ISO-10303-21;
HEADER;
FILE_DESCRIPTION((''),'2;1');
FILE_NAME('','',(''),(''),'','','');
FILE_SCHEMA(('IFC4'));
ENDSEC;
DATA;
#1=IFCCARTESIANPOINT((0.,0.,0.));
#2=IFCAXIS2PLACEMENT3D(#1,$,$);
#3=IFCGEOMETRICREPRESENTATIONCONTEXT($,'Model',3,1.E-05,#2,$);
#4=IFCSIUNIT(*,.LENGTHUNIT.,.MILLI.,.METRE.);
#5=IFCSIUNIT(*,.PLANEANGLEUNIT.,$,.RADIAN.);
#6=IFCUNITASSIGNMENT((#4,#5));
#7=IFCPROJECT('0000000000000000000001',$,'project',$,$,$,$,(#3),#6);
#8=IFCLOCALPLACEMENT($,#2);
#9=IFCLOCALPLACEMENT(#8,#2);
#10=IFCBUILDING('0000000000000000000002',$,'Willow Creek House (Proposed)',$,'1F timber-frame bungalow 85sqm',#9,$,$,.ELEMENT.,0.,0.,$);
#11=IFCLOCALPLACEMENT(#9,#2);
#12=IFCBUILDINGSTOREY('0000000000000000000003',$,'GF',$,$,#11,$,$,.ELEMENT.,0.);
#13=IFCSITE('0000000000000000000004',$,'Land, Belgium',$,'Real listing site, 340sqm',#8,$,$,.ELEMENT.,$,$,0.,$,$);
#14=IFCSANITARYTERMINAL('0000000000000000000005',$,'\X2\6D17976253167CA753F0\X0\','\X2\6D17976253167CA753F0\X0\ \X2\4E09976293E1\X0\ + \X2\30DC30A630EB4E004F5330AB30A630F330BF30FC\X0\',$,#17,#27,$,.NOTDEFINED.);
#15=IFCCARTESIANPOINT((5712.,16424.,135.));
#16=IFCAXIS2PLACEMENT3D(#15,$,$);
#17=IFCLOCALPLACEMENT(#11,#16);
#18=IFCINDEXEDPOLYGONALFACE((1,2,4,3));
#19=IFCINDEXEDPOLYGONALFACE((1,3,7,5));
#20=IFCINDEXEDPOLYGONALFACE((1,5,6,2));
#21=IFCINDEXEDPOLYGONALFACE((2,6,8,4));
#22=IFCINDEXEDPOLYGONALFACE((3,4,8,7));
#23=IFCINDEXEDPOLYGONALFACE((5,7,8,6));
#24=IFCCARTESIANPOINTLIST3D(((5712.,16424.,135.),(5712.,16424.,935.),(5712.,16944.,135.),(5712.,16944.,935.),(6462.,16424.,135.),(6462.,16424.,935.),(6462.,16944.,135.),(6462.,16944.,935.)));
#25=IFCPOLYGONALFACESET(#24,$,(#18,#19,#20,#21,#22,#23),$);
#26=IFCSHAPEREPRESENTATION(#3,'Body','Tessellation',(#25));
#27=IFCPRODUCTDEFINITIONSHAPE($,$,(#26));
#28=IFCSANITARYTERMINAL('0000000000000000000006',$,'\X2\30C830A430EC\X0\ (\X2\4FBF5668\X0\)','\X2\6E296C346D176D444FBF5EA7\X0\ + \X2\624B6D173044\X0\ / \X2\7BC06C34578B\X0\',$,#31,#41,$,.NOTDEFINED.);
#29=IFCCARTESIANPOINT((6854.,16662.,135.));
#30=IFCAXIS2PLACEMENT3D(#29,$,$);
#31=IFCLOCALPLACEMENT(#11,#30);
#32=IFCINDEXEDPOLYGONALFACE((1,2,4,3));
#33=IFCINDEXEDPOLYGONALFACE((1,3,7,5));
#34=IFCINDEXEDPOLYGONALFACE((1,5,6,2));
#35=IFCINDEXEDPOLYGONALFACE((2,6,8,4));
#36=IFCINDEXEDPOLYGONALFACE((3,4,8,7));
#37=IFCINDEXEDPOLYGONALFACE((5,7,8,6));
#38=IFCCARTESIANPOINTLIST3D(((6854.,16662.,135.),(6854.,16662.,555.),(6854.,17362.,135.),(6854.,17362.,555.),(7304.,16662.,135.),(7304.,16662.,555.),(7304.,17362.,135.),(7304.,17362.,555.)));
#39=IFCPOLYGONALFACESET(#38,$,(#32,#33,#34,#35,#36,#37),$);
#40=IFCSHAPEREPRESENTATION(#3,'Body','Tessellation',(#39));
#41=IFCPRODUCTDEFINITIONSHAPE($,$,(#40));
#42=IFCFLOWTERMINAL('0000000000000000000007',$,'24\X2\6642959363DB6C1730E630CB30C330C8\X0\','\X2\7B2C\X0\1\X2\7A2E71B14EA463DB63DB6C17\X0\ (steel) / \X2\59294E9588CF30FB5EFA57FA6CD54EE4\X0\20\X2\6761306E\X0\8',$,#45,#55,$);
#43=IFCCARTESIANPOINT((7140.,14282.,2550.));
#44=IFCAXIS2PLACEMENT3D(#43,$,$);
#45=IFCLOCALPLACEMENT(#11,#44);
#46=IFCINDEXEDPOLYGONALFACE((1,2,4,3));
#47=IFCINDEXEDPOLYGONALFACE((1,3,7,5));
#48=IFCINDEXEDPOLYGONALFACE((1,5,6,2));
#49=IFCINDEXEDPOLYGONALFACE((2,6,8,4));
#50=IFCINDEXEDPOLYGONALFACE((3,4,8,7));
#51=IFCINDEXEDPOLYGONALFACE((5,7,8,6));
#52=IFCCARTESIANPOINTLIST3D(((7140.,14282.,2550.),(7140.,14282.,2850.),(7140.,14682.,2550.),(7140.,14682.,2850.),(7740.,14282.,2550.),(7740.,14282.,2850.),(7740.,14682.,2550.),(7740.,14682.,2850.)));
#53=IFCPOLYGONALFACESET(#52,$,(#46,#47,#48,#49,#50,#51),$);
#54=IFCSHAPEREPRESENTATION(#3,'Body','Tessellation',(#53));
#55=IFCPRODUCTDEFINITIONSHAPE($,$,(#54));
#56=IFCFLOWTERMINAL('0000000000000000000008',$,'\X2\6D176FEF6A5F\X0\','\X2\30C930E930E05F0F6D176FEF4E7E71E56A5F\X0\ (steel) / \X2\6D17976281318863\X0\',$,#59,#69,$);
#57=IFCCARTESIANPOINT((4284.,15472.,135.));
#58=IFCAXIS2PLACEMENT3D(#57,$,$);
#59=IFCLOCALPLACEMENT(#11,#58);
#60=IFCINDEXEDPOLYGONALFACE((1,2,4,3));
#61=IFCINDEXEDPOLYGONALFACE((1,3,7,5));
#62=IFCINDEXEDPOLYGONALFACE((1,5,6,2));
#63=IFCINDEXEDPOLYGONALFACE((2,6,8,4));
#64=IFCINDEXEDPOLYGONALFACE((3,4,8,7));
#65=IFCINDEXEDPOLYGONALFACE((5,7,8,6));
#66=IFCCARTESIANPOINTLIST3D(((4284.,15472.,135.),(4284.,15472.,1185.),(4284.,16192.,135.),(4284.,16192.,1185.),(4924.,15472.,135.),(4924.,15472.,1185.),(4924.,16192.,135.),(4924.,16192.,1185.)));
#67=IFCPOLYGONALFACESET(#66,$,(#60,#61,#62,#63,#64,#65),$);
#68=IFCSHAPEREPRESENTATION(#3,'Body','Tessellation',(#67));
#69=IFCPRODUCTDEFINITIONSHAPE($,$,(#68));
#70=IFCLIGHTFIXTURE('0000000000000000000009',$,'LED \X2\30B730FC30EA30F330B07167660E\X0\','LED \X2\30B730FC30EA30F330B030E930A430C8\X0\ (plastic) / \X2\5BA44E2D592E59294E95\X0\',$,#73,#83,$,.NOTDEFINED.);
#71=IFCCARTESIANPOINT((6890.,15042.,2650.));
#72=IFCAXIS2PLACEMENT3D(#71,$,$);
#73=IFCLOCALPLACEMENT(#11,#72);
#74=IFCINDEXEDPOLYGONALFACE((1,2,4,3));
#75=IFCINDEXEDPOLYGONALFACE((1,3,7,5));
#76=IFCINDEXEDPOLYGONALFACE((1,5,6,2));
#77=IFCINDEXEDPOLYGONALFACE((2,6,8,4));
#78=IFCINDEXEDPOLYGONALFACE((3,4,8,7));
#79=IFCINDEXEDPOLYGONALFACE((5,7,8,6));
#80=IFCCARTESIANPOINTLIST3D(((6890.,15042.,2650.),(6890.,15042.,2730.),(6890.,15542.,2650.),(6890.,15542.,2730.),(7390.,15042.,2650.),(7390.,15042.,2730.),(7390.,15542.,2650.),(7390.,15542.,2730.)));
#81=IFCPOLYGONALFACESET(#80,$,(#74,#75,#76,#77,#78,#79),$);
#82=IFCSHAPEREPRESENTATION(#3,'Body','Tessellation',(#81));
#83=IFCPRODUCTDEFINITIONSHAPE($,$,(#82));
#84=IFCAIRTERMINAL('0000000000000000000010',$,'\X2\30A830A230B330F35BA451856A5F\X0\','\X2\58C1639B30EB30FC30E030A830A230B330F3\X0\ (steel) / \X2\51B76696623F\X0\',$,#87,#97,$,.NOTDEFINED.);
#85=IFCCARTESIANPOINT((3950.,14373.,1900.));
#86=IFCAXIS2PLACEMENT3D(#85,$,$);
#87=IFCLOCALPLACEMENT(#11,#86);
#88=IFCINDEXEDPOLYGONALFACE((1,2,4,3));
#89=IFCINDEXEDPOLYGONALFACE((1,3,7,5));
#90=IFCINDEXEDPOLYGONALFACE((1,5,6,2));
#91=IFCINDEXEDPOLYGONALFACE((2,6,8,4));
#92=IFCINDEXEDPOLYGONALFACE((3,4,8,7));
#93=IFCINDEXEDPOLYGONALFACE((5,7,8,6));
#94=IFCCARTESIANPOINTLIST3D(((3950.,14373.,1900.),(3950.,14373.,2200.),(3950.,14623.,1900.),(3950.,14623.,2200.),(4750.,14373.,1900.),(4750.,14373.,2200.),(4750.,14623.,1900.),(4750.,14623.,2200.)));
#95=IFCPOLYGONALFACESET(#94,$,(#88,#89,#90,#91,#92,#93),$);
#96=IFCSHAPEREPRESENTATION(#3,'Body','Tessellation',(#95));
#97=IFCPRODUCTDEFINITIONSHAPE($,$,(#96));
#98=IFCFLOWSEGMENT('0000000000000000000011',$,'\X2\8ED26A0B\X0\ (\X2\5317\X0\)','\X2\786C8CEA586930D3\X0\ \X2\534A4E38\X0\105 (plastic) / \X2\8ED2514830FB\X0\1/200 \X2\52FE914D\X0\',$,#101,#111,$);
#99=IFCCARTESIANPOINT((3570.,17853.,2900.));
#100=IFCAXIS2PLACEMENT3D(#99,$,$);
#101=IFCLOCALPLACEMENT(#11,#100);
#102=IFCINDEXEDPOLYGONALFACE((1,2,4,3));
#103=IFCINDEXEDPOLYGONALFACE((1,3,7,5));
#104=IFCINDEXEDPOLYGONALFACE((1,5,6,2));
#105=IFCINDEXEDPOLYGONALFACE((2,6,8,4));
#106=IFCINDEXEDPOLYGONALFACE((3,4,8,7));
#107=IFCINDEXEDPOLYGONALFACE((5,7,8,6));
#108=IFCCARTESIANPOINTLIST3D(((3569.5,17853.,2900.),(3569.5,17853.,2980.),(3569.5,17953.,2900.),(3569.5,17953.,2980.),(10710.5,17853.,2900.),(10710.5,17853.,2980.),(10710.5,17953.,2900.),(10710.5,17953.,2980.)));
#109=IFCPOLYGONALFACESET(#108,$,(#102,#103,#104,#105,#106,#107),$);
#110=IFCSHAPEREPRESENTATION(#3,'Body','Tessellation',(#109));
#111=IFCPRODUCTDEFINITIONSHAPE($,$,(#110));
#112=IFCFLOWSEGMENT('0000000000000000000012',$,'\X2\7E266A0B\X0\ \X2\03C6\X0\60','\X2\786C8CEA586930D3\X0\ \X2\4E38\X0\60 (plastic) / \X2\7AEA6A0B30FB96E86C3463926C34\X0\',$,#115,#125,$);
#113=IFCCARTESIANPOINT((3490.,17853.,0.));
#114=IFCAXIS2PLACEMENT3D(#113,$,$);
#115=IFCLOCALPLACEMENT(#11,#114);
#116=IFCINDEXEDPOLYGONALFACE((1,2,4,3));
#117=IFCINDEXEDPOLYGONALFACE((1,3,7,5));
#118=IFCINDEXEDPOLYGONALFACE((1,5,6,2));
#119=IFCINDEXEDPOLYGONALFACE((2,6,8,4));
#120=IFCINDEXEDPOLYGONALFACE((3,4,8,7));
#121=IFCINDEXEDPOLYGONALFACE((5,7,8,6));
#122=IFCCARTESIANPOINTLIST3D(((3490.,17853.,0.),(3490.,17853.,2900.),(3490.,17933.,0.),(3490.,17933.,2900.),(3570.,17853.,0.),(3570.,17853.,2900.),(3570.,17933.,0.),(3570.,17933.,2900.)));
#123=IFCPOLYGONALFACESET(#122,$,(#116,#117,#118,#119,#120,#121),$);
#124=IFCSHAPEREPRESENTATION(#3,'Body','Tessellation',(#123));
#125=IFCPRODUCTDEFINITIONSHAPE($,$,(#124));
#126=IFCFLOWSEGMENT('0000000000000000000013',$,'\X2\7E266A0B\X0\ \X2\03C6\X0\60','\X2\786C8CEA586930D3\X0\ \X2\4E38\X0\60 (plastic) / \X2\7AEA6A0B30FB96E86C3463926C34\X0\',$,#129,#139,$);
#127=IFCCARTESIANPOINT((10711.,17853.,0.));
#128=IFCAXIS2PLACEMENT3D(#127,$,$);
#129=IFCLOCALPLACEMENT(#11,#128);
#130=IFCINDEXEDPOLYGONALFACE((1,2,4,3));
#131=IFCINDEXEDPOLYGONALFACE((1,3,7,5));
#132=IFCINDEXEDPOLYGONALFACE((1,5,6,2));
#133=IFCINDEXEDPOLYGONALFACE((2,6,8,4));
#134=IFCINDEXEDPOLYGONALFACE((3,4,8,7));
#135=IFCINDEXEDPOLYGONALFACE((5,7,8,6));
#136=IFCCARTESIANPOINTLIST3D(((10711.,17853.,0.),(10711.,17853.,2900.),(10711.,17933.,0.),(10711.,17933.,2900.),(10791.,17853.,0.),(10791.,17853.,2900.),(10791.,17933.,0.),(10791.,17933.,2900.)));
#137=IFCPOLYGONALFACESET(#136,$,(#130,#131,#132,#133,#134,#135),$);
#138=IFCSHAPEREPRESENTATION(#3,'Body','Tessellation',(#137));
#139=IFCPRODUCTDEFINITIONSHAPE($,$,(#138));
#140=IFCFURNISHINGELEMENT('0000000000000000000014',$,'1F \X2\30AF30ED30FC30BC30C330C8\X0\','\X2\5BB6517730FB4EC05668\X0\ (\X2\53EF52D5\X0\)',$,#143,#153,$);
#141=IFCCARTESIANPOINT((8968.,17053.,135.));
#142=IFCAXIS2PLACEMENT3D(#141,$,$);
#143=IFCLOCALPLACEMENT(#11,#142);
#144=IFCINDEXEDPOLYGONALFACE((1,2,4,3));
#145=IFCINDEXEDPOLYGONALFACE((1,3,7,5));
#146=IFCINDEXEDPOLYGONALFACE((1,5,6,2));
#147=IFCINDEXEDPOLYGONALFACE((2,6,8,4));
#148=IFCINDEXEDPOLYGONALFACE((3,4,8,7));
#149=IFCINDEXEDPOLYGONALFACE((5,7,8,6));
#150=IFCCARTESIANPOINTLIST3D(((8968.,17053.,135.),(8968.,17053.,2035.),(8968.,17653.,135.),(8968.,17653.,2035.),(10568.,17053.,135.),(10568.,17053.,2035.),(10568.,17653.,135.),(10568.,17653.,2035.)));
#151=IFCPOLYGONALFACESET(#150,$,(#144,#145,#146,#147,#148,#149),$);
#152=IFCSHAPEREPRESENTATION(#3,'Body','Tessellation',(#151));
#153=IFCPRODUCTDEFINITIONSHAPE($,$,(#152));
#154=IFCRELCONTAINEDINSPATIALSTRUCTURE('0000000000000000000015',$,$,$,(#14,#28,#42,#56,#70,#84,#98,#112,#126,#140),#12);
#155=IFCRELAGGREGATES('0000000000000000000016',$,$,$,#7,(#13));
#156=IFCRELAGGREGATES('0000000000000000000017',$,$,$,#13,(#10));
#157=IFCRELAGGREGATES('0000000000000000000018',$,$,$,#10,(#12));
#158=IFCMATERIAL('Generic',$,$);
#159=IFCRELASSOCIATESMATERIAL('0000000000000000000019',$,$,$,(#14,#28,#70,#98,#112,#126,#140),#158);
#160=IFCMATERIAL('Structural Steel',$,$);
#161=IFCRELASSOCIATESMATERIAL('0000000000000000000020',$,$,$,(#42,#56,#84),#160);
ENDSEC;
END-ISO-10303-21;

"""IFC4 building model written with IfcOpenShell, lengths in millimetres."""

from ifc_helpers import new_model, si_unit, frame, frame_2d, origin, place, context, project, spatial, rectangle, extrude, material, element, save


model = new_model("IFC4")

# Units and contexts
model_context = context("Model", 3, precision=1e-05, world=origin())
ifc_project = project(units=[si_unit("LENGTHUNIT", "METRE", prefix="MILLI"), si_unit("PLANEANGLEUNIT", "RADIAN")], contexts=[model_context])

# Site, building, storey
site_placement = place(None, origin())
site = spatial("IfcSite", under=ifc_project, at=site_placement, Name="Land, Belgium", ObjectType="Real listing site, 340sqm", CompositionType="ELEMENT", RefElevation=0.0)
building_placement = place(site_placement, origin())
building = spatial("IfcBuilding", under=site, at=building_placement, Name="Willow Creek House (Proposed)", ObjectType="1F timber-frame bungalow 85sqm", CompositionType="ELEMENT", ElevationOfRefHeight=0.0, ElevationOfTerrain=0.0)
storey_placement = place(building_placement, origin())
storey = spatial("IfcBuildingStorey", under=building, at=storey_placement, Name="GF", CompositionType="ELEMENT", Elevation=0.0)

# Shared definitions
ifc_material_1 = material(Name="Generic")

# Sanitary terminals
sanitary_terminal_1_placement = place(storey_placement, frame((5712.0, 16424.0, 135.0)))
element("IfcSanitaryTerminal", 1, at=sanitary_terminal_1_placement, inside=storey, material=ifc_material_1, Name="洗面化粧台", Description="洗面化粧台 三面鏡 + ボウル一体カウンター", PredefinedType="NOTDEFINED", context=model_context, shape_type="SweptSolid", body=[
    extrude(rectangle(XDim=750.0, YDim=520.0, at=frame_2d((375.0, 260.0))), frame((5712.0, 16424.0, 135.0)), (0.0, 0.0, 1.0), 800.0),
])
sanitary_terminal_2_placement = place(storey_placement, frame((6854.0, 16662.0, 135.0)))
element("IfcSanitaryTerminal", 2, at=sanitary_terminal_2_placement, inside=storey, material=ifc_material_1, Name="トイレ (便器)", Description="温水洗浄便座 + 手洗い / 節水型", PredefinedType="NOTDEFINED", context=model_context, shape_type="SweptSolid", body=[
    extrude(rectangle(XDim=450.0, YDim=700.0, at=frame_2d((225.0, 350.0))), frame((6854.0, 16662.0, 135.0)), (0.0, 0.0, 1.0), 420.0),
])

# Flow terminals
ifc_material_2 = material(Name="Structural Steel")
flow_terminal_1_placement = place(storey_placement, frame((7140.0, 14282.0, 2550.0)))
element("IfcFlowTerminal", 3, at=flow_terminal_1_placement, inside=storey, material=ifc_material_2, Name="24時間換気ユニット", Description="第1種熱交換換気 (steel) / 天井裏・建基法令20条の8", context=model_context, shape_type="SweptSolid", body=[
    extrude(rectangle(XDim=600.0, YDim=400.0, at=frame_2d((300.0, 200.0))), frame((7140.0, 14282.0, 2550.0)), (0.0, 0.0, 1.0), 300.0),
])
flow_terminal_2_placement = place(storey_placement, frame((4284.0, 15472.0, 135.0)))
element("IfcFlowTerminal", 4, at=flow_terminal_2_placement, inside=storey, material=ifc_material_2, Name="洗濯機", Description="ドラム式洗濯乾燥機 (steel) / 洗面脱衣", context=model_context, shape_type="SweptSolid", body=[
    extrude(rectangle(XDim=640.0, YDim=720.0, at=frame_2d((320.0, 360.0))), frame((4284.0, 15472.0, 135.0)), (0.0, 0.0, 1.0), 1050.0),
])

# Light fixture
light_fixture_placement = place(storey_placement, frame((6890.0, 15042.0, 2650.0)))
element("IfcLightFixture", 5, at=light_fixture_placement, inside=storey, material=ifc_material_1, Name="LED シーリング照明", Description="LED シーリングライト (plastic) / 室中央天井", PredefinedType="NOTDEFINED", context=model_context, shape_type="SweptSolid", body=[
    extrude(rectangle(XDim=500.0, YDim=500.0, at=frame_2d((250.0, 250.0))), frame((6890.0, 15042.0, 2650.0)), (0.0, 0.0, 1.0), 80.0),
])

# Air terminal
air_terminal_placement = place(storey_placement, frame((3950.0, 14373.0, 1900.0)))
element("IfcAirTerminal", 6, at=air_terminal_placement, inside=storey, material=ifc_material_2, Name="エアコン室内機", Description="壁掛ルームエアコン (steel) / 冷暖房", PredefinedType="NOTDEFINED", context=model_context, shape_type="SweptSolid", body=[
    extrude(rectangle(XDim=800.0, YDim=250.0, at=frame_2d((400.0, 125.0))), frame((3950.0, 14373.0, 1900.0)), (0.0, 0.0, 1.0), 300.0),
])

# Flow segments
flow_segment_1_placement = place(storey_placement, frame((3570.0, 17853.0, 2900.0)))
element("IfcFlowSegment", 7, at=flow_segment_1_placement, inside=storey, material=ifc_material_1, Name="軒樋 (北)", Description="硬質塩ビ 半丸105 (plastic) / 軒先・1/200 勾配", context=model_context, shape_type="SweptSolid", body=[
    extrude(rectangle(XDim=7141.0, YDim=100.0, at=frame_2d((3570.0, 50.0))), frame((3570.0, 17853.0, 2900.0)), (0.0, 0.0, 1.0), 80.0),
])
flow_segment_2_placement = place(storey_placement, frame((3490.0, 17853.0, 0.0)))
element("IfcFlowSegment", 8, at=flow_segment_2_placement, inside=storey, material=ifc_material_1, Name="縦樋 φ60", Description="硬質塩ビ 丸60 (plastic) / 竪樋・雨水排水", context=model_context, shape_type="SweptSolid", body=[
    extrude(rectangle(XDim=80.0, YDim=80.0, at=frame_2d((40.0, 40.0))), frame((3490.0, 17853.0, 0.0)), (0.0, 0.0, 1.0), 2900.0),
])
flow_segment_3_placement = place(storey_placement, frame((10711.0, 17853.0, 0.0)))
element("IfcFlowSegment", 9, at=flow_segment_3_placement, inside=storey, material=ifc_material_1, Name="縦樋 φ60", Description="硬質塩ビ 丸60 (plastic) / 竪樋・雨水排水", context=model_context, shape_type="SweptSolid", body=[
    extrude(rectangle(XDim=80.0, YDim=80.0, at=frame_2d((40.0, 40.0))), frame((10711.0, 17853.0, 0.0)), (0.0, 0.0, 1.0), 2900.0),
])

# Furnishing element
furnishing_placement = place(storey_placement, frame((8968.0, 17053.0, 135.0)))
element("IfcFurnishingElement", 10, at=furnishing_placement, inside=storey, material=ifc_material_1, Name="1F クローゼット", Description="家具・什器 (可動)", context=model_context, shape_type="SweptSolid", body=[
    extrude(rectangle(XDim=1600.0, YDim=600.0, at=frame_2d((800.0, 300.0))), frame((8968.0, 17053.0, 135.0)), (0.0, 0.0, 1.0), 1900.0),
])

save(model, "model.ifc")
